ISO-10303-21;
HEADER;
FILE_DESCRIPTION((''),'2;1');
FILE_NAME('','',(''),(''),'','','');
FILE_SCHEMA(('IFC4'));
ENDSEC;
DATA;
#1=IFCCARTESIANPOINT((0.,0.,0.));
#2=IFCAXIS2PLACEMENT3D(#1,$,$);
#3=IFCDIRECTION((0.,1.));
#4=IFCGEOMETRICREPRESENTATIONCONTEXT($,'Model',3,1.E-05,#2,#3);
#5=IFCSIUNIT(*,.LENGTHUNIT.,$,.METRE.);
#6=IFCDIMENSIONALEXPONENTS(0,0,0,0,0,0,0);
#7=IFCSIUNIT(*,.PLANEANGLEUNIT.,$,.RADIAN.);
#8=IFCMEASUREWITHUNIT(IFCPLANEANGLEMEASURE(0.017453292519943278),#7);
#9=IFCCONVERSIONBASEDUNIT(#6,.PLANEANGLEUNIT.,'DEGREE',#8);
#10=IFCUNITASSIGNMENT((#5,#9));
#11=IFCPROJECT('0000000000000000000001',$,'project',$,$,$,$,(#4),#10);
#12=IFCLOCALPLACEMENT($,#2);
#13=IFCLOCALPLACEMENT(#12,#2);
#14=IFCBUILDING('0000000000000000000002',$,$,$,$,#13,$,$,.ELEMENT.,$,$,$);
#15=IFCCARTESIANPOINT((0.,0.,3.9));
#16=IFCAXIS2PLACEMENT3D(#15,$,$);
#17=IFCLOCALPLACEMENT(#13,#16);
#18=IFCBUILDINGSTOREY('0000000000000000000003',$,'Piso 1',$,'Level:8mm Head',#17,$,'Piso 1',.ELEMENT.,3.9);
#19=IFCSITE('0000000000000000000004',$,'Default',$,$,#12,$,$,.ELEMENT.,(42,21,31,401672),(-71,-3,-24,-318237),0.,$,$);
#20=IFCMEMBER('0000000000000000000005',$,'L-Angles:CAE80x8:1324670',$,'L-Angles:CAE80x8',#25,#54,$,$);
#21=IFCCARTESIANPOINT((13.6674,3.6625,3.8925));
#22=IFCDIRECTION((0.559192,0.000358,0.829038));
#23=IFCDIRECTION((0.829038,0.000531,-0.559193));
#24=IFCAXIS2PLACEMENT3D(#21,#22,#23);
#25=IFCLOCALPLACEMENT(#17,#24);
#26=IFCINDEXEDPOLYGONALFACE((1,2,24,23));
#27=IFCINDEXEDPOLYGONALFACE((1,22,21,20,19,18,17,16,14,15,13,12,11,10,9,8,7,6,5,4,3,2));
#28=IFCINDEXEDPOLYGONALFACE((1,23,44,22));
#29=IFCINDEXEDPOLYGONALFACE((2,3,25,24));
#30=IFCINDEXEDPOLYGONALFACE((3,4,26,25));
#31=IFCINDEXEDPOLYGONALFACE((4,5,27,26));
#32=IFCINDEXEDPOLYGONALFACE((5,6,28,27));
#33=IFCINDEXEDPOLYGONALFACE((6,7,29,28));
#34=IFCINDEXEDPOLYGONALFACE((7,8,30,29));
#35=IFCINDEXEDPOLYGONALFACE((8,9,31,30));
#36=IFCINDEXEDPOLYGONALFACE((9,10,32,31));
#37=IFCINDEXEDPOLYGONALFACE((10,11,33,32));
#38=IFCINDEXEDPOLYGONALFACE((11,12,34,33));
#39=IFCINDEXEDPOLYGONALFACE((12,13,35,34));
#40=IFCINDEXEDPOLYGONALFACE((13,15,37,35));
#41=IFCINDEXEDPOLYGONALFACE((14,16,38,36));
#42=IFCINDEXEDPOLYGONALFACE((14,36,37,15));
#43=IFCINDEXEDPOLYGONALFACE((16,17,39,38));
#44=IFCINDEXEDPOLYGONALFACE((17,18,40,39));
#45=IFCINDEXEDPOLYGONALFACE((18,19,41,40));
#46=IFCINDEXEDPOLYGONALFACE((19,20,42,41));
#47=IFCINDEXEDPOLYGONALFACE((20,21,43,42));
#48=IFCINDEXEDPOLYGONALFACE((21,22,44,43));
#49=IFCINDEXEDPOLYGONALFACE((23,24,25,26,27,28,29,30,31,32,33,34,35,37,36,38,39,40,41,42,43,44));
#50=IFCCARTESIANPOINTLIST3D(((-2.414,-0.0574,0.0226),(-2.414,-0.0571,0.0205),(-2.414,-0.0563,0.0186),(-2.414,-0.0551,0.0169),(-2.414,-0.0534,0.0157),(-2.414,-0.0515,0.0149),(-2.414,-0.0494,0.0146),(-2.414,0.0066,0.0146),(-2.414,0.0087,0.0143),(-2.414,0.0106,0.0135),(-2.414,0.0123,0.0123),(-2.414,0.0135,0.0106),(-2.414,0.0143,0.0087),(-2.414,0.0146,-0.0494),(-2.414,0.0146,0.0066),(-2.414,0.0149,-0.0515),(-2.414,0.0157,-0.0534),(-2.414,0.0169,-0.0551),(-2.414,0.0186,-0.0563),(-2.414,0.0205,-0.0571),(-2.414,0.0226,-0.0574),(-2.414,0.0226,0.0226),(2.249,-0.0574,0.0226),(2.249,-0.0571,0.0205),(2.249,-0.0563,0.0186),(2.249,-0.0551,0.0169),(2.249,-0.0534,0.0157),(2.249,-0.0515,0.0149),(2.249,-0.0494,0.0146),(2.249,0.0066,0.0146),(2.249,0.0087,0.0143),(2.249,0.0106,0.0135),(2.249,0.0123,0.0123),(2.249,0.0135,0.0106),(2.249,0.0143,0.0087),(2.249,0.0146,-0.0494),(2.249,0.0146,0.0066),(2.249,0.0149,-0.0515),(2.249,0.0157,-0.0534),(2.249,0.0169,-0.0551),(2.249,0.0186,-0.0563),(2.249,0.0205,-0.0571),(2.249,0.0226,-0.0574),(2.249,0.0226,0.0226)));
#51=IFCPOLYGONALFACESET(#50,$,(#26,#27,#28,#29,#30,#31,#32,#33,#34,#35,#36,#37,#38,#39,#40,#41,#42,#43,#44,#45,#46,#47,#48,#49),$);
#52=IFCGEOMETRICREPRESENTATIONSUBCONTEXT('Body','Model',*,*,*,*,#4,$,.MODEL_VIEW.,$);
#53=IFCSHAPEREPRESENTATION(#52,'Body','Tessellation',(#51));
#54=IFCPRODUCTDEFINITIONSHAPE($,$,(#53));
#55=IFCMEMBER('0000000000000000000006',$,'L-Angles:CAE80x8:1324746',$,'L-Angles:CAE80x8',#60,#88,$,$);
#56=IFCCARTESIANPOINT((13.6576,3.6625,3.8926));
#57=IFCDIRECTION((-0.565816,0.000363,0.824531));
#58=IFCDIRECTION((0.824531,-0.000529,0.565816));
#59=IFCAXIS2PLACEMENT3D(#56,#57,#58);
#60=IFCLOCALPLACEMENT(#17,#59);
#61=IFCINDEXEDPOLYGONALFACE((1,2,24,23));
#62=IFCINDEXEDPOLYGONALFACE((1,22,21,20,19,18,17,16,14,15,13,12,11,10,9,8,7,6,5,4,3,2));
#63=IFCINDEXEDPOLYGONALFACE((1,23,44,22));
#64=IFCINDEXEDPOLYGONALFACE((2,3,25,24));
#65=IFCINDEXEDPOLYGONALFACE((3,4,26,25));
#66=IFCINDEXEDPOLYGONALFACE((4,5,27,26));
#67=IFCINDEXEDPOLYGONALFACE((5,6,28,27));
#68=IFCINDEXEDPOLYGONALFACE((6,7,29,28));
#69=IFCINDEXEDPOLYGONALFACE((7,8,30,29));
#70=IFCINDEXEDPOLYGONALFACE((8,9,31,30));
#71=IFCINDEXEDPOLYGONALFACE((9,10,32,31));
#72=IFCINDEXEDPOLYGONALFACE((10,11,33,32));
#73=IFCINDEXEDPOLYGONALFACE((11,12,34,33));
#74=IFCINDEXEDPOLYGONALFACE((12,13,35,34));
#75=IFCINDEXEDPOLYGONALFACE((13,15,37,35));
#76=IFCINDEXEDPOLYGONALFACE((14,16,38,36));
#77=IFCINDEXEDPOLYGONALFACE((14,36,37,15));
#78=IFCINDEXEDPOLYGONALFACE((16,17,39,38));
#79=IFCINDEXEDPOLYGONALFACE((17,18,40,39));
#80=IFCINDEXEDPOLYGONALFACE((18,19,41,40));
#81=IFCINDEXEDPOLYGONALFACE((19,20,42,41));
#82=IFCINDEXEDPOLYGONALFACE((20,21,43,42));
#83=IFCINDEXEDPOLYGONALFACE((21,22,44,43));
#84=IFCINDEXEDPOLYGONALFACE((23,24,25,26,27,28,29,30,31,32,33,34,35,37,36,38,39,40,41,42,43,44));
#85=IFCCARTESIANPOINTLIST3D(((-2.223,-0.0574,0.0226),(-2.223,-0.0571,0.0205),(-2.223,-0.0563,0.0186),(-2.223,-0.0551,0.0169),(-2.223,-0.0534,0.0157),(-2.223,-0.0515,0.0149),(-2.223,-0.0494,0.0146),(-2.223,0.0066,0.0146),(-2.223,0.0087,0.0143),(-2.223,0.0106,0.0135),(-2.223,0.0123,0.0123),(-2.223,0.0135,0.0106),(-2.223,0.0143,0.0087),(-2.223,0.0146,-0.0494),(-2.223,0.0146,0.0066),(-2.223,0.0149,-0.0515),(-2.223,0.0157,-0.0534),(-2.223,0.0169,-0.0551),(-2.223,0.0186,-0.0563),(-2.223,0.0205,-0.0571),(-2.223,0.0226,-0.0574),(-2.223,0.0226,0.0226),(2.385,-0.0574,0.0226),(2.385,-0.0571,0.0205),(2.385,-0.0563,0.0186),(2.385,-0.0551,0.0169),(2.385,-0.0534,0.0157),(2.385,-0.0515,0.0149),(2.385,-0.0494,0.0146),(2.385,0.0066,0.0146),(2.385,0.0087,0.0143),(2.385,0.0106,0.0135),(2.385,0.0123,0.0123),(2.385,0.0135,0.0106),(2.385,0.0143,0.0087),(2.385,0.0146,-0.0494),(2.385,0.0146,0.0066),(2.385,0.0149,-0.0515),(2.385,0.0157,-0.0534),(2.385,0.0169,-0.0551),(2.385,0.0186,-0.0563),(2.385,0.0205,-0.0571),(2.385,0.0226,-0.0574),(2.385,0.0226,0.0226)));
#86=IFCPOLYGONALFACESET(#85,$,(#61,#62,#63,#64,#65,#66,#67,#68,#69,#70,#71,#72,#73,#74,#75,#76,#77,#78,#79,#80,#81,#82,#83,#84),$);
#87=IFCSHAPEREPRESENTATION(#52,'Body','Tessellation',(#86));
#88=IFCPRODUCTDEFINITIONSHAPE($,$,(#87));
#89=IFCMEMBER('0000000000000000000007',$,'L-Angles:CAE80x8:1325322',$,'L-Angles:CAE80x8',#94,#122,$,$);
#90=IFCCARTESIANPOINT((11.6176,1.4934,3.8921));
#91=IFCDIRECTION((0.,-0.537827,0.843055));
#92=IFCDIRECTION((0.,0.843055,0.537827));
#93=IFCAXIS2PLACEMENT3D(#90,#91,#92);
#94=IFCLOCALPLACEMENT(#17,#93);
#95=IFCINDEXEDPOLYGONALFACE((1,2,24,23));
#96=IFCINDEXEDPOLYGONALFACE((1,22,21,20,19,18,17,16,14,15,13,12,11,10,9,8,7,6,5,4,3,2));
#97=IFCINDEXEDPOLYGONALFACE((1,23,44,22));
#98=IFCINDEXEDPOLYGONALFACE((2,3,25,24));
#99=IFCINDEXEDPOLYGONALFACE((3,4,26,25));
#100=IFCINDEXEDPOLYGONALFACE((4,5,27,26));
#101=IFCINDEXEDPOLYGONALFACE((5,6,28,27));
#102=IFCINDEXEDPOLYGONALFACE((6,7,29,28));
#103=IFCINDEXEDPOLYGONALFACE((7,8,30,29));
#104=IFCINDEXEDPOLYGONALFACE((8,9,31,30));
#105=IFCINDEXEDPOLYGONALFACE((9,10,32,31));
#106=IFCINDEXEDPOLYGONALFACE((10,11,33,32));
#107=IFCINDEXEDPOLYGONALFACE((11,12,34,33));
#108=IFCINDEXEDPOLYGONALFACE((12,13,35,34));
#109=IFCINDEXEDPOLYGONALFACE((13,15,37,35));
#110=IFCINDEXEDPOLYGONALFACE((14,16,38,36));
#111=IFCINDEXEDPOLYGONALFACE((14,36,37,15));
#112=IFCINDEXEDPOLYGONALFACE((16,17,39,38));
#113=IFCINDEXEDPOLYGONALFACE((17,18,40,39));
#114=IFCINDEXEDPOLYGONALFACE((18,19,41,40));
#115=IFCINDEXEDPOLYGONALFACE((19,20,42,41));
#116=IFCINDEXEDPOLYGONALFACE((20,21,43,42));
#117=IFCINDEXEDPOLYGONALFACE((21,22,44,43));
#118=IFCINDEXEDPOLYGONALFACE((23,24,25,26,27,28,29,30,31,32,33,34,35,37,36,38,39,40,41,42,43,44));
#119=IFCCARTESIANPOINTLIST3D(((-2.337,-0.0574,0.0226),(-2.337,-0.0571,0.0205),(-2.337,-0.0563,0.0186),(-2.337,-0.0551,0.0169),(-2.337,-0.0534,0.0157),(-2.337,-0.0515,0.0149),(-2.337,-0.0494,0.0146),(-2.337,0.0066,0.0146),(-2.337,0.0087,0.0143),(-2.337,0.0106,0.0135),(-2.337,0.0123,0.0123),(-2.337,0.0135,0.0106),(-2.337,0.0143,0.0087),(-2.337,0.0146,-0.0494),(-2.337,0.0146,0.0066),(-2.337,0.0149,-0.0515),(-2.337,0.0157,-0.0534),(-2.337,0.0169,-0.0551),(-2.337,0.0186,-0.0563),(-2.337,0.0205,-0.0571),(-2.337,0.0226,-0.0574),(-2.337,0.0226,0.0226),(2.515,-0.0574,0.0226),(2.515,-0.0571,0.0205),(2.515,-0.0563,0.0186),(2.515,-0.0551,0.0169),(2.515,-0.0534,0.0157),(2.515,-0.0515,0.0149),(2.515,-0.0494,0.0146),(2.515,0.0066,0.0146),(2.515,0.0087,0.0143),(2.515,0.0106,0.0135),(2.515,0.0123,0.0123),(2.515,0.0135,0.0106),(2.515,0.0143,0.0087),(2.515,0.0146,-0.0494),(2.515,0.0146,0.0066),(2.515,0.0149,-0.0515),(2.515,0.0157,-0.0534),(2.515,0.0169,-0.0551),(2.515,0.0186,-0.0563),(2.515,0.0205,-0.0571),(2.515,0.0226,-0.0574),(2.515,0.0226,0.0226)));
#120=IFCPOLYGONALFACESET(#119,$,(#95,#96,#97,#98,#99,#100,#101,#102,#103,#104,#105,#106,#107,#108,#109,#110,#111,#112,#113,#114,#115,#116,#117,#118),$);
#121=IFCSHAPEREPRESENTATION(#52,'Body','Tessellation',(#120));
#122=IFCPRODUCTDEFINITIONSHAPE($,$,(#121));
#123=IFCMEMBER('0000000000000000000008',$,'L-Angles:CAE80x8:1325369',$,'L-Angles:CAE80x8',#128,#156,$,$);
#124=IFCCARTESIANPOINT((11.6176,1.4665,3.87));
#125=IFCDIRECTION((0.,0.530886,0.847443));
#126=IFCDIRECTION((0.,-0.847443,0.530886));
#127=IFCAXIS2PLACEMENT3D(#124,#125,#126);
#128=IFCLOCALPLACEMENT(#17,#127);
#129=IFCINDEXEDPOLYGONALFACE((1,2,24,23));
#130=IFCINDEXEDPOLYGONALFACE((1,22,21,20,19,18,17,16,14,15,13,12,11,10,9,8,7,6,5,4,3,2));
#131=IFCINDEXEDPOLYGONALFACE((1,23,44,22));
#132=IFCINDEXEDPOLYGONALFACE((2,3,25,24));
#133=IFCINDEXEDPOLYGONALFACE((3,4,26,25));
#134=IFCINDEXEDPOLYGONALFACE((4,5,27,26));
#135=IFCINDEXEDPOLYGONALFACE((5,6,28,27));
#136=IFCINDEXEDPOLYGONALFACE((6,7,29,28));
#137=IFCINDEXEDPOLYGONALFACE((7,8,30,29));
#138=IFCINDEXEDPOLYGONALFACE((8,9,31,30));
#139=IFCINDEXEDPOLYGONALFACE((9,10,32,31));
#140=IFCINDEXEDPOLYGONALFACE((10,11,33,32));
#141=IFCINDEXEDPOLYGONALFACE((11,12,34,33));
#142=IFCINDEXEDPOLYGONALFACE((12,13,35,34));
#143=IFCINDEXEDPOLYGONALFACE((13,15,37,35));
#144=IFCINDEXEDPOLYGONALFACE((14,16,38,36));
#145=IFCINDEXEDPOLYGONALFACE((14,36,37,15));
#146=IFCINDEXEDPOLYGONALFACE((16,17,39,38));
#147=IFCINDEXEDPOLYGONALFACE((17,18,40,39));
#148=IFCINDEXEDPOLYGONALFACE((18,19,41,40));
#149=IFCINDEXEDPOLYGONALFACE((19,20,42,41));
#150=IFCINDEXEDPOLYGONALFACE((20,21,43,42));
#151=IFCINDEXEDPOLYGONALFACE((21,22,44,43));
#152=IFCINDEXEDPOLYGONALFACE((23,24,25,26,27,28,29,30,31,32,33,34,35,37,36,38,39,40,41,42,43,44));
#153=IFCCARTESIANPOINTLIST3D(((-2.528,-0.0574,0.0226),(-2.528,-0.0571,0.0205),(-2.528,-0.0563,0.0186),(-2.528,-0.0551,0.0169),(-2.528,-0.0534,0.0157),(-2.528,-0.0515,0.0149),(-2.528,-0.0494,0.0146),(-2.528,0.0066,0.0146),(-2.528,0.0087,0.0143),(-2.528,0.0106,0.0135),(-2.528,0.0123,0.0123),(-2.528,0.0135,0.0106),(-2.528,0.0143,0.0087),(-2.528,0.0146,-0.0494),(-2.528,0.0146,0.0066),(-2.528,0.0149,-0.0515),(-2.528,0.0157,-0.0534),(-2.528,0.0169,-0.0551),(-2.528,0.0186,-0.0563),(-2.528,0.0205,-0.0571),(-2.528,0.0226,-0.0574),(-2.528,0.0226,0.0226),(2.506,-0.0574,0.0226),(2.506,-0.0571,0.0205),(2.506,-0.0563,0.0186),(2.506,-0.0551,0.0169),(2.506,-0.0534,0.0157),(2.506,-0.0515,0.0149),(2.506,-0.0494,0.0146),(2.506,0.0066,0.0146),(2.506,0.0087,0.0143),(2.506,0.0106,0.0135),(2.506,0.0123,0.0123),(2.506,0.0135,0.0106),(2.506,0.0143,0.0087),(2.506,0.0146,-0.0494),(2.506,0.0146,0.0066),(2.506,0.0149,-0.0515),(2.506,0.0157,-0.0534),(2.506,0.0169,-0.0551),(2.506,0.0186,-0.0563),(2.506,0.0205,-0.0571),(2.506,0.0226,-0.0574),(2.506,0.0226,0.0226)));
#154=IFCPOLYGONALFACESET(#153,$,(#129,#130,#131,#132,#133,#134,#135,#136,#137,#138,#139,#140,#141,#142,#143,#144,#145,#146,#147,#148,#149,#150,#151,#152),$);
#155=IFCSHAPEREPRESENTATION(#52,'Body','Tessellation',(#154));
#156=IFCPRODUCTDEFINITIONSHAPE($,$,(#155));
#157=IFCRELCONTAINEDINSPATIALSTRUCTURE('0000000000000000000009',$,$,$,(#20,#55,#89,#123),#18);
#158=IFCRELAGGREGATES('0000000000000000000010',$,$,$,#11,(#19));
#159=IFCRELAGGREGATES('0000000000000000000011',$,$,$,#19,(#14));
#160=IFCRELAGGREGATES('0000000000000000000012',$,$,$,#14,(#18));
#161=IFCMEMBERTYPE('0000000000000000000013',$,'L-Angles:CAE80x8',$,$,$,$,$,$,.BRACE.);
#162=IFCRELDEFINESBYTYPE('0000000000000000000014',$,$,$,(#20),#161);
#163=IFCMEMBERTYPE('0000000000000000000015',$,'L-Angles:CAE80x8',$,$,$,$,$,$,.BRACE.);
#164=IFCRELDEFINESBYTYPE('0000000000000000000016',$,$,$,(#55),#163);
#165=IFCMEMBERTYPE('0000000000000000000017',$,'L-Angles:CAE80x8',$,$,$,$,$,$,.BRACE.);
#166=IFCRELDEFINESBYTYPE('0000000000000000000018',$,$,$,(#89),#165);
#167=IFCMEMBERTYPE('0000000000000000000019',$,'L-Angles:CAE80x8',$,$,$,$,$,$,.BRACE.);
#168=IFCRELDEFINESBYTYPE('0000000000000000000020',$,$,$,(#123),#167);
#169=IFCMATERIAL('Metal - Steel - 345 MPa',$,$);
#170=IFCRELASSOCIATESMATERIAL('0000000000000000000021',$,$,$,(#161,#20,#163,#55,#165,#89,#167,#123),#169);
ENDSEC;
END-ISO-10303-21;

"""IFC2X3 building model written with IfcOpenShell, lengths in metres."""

from ifc_helpers import new_model, entity, si_unit, converted_unit, direction, frame, frame_2d, origin, place, context, subcontext, project, spatial, polyline, circle_curve, parameter, trimmed, segment, composite_curve, outline, extrude, source, transform, mapped, material, type_object, type_shapes, element, save


model = new_model("IFC2X3")

# Units and contexts
model_context = context("Model", 3, precision=1e-05, world=origin(), true_north=direction((0.0, 1.0)))
body_context = subcontext(model_context, "Body", "Model", "MODEL_VIEW")
ifc_project = project(units=[si_unit("LENGTHUNIT", "METRE"), converted_unit("PLANEANGLEUNIT", "DEGREE", entity("IfcPlaneAngleMeasure", 0.017453292519943278), si_unit("PLANEANGLEUNIT", "RADIAN"), dimensions=[0, 0, 0, 0, 0, 0, 0])], contexts=[model_context])

# Site, building, storey
site_placement = place(None, origin())
site = spatial("IfcSite", under=ifc_project, at=site_placement, Name="Default", CompositionType="ELEMENT", RefLatitude=(42, 21, 31, 401672), RefLongitude=(-71, -3, -24, -318237), RefElevation=0.0)
building_placement = place(site_placement, origin())
building = spatial("IfcBuilding", under=site, at=building_placement, CompositionType="ELEMENT")
storey_placement = place(building_placement, frame((0.0, 0.0, 3.9)))
storey = spatial("IfcBuildingStorey", under=building, at=storey_placement, Name="Piso 1", ObjectType="Level:8mm Head", LongName="Piso 1", CompositionType="ELEMENT", Elevation=3.9)

# Shared definitions
ifc_material = material(Name="Metal - Steel - 345 MPa")

# Members
member_type_1 = type_object("IfcMemberType", Name="L-Angles:CAE80x8", PredefinedType="BRACE", material=ifc_material)
shared_shape_1 = source(origin(), body_context, "Body", "SweptSolid", [
    extrude(outline(composite_curve([segment(polyline([(-0.0263, -0.0263), (0.0537, -0.0263)]), True, "CONTINUOUS"), segment(trimmed(circle_curve(frame_2d((0.0457, -0.0263), x_axis=(1.0, 0.0)), 0.008), [parameter(0.0)], [parameter(90.0)], True, "PARAMETER"), True, "CONTINUOUS"), segment(polyline([(0.0457, -0.0183), (-0.0103, -0.0183)]), True, "CONTINUOUS"), segment(trimmed(circle_curve(frame_2d((-0.0103, -0.0103), x_axis=(1.0, 0.0)), 0.008), [parameter(180.0)], [parameter(270.0)], True, "PARAMETER"), False, "CONTINUOUS"), segment(polyline([(-0.0183, -0.0103), (-0.0183, 0.0457)]), True, "CONTINUOUS"), segment(trimmed(circle_curve(frame_2d((-0.0263, 0.0457), x_axis=(1.0, 0.0)), 0.008), [parameter(0.0)], [parameter(90.0)], True, "PARAMETER"), True, "CONTINUOUS"), segment(polyline([(-0.0263, 0.0537), (-0.0263, -0.0263)]), True, "CONTINUOUS")], self_intersect=False)), frame((-2.414, -0.0037, -0.0037), z_axis=(1.0, 0.0, 0.0), x_axis=(0.0, -1.0, 0.0)), (0.0, 0.0, 1.0), 4.663),
])
type_shapes(member_type_1, [shared_shape_1])
member_1_placement = place(storey_placement, frame((13.6674, 3.6625, 3.8925), z_axis=(0.559192, 0.000358, 0.829038), x_axis=(0.829038, 0.000531, -0.559193)))
element("IfcMember", 1, at=member_1_placement, inside=storey, type_object=member_type_1, material=ifc_material, Name="L-Angles:CAE80x8:1324670", ObjectType="L-Angles:CAE80x8", context=body_context, shape_type="MappedRepresentation", body=[
    mapped(shared_shape_1, transform((0.0, 0.0, 0.0), scale=1.0)),
])
member_type_2 = type_object("IfcMemberType", Name="L-Angles:CAE80x8", PredefinedType="BRACE", material=ifc_material)
shared_shape_2 = source(origin(), body_context, "Body", "SweptSolid", [
    extrude(outline(composite_curve([segment(polyline([(-0.0263, -0.0263), (0.0537, -0.0263)]), True, "CONTINUOUS"), segment(trimmed(circle_curve(frame_2d((0.0457, -0.0263), x_axis=(1.0, 0.0)), 0.008), [parameter(0.0)], [parameter(90.0)], True, "PARAMETER"), True, "CONTINUOUS"), segment(polyline([(0.0457, -0.0183), (-0.0103, -0.0183)]), True, "CONTINUOUS"), segment(trimmed(circle_curve(frame_2d((-0.0103, -0.0103), x_axis=(1.0, 0.0)), 0.008), [parameter(180.0)], [parameter(270.0)], True, "PARAMETER"), False, "CONTINUOUS"), segment(polyline([(-0.0183, -0.0103), (-0.0183, 0.0457)]), True, "CONTINUOUS"), segment(trimmed(circle_curve(frame_2d((-0.0263, 0.0457), x_axis=(1.0, 0.0)), 0.008), [parameter(0.0)], [parameter(90.0)], True, "PARAMETER"), True, "CONTINUOUS"), segment(polyline([(-0.0263, 0.0537), (-0.0263, -0.0263)]), True, "CONTINUOUS")], self_intersect=False)), frame((-2.223, -0.0037, -0.0037), z_axis=(1.0, 0.0, 0.0), x_axis=(0.0, -1.0, 0.0)), (0.0, 0.0, 1.0), 4.608),
])
type_shapes(member_type_2, [shared_shape_2])
member_2_placement = place(storey_placement, frame((13.6576, 3.6625, 3.8926), z_axis=(-0.565816, 0.000363, 0.824531), x_axis=(0.824531, -0.000529, 0.565816)))
element("IfcMember", 2, at=member_2_placement, inside=storey, type_object=member_type_2, material=ifc_material, Name="L-Angles:CAE80x8:1324746", ObjectType="L-Angles:CAE80x8", context=body_context, shape_type="MappedRepresentation", body=[
    mapped(shared_shape_2, transform((0.0, 0.0, 0.0), scale=1.0)),
])
member_type_3 = type_object("IfcMemberType", Name="L-Angles:CAE80x8", PredefinedType="BRACE", material=ifc_material)
shared_shape_3 = source(origin(), body_context, "Body", "SweptSolid", [
    extrude(outline(composite_curve([segment(polyline([(-0.0263, -0.0263), (0.0537, -0.0263)]), True, "CONTINUOUS"), segment(trimmed(circle_curve(frame_2d((0.0457, -0.0263), x_axis=(1.0, 0.0)), 0.008), [parameter(0.0)], [parameter(90.0)], True, "PARAMETER"), True, "CONTINUOUS"), segment(polyline([(0.0457, -0.0183), (-0.0103, -0.0183)]), True, "CONTINUOUS"), segment(trimmed(circle_curve(frame_2d((-0.0103, -0.0103), x_axis=(1.0, 0.0)), 0.008), [parameter(180.0)], [parameter(270.0)], True, "PARAMETER"), False, "CONTINUOUS"), segment(polyline([(-0.0183, -0.0103), (-0.0183, 0.0457)]), True, "CONTINUOUS"), segment(trimmed(circle_curve(frame_2d((-0.0263, 0.0457), x_axis=(1.0, 0.0)), 0.008), [parameter(0.0)], [parameter(90.0)], True, "PARAMETER"), True, "CONTINUOUS"), segment(polyline([(-0.0263, 0.0537), (-0.0263, -0.0263)]), True, "CONTINUOUS")], self_intersect=False)), frame((-2.337, -0.0037, -0.0037), z_axis=(1.0, 0.0, 0.0), x_axis=(0.0, -1.0, 0.0)), (0.0, 0.0, 1.0), 4.852),
])
type_shapes(member_type_3, [shared_shape_3])
member_3_placement = place(storey_placement, frame((11.6176, 1.4934, 3.8921), z_axis=(0.0, -0.537827, 0.843055), x_axis=(0.0, 0.843055, 0.537827)))
element("IfcMember", 3, at=member_3_placement, inside=storey, type_object=member_type_3, material=ifc_material, Name="L-Angles:CAE80x8:1325322", ObjectType="L-Angles:CAE80x8", context=body_context, shape_type="MappedRepresentation", body=[
    mapped(shared_shape_3, transform((0.0, 0.0, 0.0), scale=1.0)),
])
member_type_4 = type_object("IfcMemberType", Name="L-Angles:CAE80x8", PredefinedType="BRACE", material=ifc_material)
shared_shape_4 = source(origin(), body_context, "Body", "SweptSolid", [
    extrude(outline(composite_curve([segment(polyline([(-0.0263, -0.0263), (0.0537, -0.0263)]), True, "CONTINUOUS"), segment(trimmed(circle_curve(frame_2d((0.0457, -0.0263), x_axis=(1.0, 0.0)), 0.008), [parameter(0.0)], [parameter(90.0)], True, "PARAMETER"), True, "CONTINUOUS"), segment(polyline([(0.0457, -0.0183), (-0.0103, -0.0183)]), True, "CONTINUOUS"), segment(trimmed(circle_curve(frame_2d((-0.0103, -0.0103), x_axis=(1.0, 0.0)), 0.008), [parameter(180.0)], [parameter(270.0)], True, "PARAMETER"), False, "CONTINUOUS"), segment(polyline([(-0.0183, -0.0103), (-0.0183, 0.0457)]), True, "CONTINUOUS"), segment(trimmed(circle_curve(frame_2d((-0.0263, 0.0457), x_axis=(1.0, 0.0)), 0.008), [parameter(0.0)], [parameter(90.0)], True, "PARAMETER"), True, "CONTINUOUS"), segment(polyline([(-0.0263, 0.0537), (-0.0263, -0.0263)]), True, "CONTINUOUS")], self_intersect=False)), frame((-2.528, -0.0037, -0.0037), z_axis=(1.0, 0.0, 0.0), x_axis=(0.0, -1.0, 0.0)), (0.0, 0.0, 1.0), 5.034),
])
type_shapes(member_type_4, [shared_shape_4])
member_4_placement = place(storey_placement, frame((11.6176, 1.4665, 3.87), z_axis=(0.0, 0.530886, 0.847443), x_axis=(0.0, -0.847443, 0.530886)))
element("IfcMember", 4, at=member_4_placement, inside=storey, type_object=member_type_4, material=ifc_material, Name="L-Angles:CAE80x8:1325369", ObjectType="L-Angles:CAE80x8", context=body_context, shape_type="MappedRepresentation", body=[
    mapped(shared_shape_4, transform((0.0, 0.0, 0.0), scale=1.0)),
])

save(model, "model.ifc")
